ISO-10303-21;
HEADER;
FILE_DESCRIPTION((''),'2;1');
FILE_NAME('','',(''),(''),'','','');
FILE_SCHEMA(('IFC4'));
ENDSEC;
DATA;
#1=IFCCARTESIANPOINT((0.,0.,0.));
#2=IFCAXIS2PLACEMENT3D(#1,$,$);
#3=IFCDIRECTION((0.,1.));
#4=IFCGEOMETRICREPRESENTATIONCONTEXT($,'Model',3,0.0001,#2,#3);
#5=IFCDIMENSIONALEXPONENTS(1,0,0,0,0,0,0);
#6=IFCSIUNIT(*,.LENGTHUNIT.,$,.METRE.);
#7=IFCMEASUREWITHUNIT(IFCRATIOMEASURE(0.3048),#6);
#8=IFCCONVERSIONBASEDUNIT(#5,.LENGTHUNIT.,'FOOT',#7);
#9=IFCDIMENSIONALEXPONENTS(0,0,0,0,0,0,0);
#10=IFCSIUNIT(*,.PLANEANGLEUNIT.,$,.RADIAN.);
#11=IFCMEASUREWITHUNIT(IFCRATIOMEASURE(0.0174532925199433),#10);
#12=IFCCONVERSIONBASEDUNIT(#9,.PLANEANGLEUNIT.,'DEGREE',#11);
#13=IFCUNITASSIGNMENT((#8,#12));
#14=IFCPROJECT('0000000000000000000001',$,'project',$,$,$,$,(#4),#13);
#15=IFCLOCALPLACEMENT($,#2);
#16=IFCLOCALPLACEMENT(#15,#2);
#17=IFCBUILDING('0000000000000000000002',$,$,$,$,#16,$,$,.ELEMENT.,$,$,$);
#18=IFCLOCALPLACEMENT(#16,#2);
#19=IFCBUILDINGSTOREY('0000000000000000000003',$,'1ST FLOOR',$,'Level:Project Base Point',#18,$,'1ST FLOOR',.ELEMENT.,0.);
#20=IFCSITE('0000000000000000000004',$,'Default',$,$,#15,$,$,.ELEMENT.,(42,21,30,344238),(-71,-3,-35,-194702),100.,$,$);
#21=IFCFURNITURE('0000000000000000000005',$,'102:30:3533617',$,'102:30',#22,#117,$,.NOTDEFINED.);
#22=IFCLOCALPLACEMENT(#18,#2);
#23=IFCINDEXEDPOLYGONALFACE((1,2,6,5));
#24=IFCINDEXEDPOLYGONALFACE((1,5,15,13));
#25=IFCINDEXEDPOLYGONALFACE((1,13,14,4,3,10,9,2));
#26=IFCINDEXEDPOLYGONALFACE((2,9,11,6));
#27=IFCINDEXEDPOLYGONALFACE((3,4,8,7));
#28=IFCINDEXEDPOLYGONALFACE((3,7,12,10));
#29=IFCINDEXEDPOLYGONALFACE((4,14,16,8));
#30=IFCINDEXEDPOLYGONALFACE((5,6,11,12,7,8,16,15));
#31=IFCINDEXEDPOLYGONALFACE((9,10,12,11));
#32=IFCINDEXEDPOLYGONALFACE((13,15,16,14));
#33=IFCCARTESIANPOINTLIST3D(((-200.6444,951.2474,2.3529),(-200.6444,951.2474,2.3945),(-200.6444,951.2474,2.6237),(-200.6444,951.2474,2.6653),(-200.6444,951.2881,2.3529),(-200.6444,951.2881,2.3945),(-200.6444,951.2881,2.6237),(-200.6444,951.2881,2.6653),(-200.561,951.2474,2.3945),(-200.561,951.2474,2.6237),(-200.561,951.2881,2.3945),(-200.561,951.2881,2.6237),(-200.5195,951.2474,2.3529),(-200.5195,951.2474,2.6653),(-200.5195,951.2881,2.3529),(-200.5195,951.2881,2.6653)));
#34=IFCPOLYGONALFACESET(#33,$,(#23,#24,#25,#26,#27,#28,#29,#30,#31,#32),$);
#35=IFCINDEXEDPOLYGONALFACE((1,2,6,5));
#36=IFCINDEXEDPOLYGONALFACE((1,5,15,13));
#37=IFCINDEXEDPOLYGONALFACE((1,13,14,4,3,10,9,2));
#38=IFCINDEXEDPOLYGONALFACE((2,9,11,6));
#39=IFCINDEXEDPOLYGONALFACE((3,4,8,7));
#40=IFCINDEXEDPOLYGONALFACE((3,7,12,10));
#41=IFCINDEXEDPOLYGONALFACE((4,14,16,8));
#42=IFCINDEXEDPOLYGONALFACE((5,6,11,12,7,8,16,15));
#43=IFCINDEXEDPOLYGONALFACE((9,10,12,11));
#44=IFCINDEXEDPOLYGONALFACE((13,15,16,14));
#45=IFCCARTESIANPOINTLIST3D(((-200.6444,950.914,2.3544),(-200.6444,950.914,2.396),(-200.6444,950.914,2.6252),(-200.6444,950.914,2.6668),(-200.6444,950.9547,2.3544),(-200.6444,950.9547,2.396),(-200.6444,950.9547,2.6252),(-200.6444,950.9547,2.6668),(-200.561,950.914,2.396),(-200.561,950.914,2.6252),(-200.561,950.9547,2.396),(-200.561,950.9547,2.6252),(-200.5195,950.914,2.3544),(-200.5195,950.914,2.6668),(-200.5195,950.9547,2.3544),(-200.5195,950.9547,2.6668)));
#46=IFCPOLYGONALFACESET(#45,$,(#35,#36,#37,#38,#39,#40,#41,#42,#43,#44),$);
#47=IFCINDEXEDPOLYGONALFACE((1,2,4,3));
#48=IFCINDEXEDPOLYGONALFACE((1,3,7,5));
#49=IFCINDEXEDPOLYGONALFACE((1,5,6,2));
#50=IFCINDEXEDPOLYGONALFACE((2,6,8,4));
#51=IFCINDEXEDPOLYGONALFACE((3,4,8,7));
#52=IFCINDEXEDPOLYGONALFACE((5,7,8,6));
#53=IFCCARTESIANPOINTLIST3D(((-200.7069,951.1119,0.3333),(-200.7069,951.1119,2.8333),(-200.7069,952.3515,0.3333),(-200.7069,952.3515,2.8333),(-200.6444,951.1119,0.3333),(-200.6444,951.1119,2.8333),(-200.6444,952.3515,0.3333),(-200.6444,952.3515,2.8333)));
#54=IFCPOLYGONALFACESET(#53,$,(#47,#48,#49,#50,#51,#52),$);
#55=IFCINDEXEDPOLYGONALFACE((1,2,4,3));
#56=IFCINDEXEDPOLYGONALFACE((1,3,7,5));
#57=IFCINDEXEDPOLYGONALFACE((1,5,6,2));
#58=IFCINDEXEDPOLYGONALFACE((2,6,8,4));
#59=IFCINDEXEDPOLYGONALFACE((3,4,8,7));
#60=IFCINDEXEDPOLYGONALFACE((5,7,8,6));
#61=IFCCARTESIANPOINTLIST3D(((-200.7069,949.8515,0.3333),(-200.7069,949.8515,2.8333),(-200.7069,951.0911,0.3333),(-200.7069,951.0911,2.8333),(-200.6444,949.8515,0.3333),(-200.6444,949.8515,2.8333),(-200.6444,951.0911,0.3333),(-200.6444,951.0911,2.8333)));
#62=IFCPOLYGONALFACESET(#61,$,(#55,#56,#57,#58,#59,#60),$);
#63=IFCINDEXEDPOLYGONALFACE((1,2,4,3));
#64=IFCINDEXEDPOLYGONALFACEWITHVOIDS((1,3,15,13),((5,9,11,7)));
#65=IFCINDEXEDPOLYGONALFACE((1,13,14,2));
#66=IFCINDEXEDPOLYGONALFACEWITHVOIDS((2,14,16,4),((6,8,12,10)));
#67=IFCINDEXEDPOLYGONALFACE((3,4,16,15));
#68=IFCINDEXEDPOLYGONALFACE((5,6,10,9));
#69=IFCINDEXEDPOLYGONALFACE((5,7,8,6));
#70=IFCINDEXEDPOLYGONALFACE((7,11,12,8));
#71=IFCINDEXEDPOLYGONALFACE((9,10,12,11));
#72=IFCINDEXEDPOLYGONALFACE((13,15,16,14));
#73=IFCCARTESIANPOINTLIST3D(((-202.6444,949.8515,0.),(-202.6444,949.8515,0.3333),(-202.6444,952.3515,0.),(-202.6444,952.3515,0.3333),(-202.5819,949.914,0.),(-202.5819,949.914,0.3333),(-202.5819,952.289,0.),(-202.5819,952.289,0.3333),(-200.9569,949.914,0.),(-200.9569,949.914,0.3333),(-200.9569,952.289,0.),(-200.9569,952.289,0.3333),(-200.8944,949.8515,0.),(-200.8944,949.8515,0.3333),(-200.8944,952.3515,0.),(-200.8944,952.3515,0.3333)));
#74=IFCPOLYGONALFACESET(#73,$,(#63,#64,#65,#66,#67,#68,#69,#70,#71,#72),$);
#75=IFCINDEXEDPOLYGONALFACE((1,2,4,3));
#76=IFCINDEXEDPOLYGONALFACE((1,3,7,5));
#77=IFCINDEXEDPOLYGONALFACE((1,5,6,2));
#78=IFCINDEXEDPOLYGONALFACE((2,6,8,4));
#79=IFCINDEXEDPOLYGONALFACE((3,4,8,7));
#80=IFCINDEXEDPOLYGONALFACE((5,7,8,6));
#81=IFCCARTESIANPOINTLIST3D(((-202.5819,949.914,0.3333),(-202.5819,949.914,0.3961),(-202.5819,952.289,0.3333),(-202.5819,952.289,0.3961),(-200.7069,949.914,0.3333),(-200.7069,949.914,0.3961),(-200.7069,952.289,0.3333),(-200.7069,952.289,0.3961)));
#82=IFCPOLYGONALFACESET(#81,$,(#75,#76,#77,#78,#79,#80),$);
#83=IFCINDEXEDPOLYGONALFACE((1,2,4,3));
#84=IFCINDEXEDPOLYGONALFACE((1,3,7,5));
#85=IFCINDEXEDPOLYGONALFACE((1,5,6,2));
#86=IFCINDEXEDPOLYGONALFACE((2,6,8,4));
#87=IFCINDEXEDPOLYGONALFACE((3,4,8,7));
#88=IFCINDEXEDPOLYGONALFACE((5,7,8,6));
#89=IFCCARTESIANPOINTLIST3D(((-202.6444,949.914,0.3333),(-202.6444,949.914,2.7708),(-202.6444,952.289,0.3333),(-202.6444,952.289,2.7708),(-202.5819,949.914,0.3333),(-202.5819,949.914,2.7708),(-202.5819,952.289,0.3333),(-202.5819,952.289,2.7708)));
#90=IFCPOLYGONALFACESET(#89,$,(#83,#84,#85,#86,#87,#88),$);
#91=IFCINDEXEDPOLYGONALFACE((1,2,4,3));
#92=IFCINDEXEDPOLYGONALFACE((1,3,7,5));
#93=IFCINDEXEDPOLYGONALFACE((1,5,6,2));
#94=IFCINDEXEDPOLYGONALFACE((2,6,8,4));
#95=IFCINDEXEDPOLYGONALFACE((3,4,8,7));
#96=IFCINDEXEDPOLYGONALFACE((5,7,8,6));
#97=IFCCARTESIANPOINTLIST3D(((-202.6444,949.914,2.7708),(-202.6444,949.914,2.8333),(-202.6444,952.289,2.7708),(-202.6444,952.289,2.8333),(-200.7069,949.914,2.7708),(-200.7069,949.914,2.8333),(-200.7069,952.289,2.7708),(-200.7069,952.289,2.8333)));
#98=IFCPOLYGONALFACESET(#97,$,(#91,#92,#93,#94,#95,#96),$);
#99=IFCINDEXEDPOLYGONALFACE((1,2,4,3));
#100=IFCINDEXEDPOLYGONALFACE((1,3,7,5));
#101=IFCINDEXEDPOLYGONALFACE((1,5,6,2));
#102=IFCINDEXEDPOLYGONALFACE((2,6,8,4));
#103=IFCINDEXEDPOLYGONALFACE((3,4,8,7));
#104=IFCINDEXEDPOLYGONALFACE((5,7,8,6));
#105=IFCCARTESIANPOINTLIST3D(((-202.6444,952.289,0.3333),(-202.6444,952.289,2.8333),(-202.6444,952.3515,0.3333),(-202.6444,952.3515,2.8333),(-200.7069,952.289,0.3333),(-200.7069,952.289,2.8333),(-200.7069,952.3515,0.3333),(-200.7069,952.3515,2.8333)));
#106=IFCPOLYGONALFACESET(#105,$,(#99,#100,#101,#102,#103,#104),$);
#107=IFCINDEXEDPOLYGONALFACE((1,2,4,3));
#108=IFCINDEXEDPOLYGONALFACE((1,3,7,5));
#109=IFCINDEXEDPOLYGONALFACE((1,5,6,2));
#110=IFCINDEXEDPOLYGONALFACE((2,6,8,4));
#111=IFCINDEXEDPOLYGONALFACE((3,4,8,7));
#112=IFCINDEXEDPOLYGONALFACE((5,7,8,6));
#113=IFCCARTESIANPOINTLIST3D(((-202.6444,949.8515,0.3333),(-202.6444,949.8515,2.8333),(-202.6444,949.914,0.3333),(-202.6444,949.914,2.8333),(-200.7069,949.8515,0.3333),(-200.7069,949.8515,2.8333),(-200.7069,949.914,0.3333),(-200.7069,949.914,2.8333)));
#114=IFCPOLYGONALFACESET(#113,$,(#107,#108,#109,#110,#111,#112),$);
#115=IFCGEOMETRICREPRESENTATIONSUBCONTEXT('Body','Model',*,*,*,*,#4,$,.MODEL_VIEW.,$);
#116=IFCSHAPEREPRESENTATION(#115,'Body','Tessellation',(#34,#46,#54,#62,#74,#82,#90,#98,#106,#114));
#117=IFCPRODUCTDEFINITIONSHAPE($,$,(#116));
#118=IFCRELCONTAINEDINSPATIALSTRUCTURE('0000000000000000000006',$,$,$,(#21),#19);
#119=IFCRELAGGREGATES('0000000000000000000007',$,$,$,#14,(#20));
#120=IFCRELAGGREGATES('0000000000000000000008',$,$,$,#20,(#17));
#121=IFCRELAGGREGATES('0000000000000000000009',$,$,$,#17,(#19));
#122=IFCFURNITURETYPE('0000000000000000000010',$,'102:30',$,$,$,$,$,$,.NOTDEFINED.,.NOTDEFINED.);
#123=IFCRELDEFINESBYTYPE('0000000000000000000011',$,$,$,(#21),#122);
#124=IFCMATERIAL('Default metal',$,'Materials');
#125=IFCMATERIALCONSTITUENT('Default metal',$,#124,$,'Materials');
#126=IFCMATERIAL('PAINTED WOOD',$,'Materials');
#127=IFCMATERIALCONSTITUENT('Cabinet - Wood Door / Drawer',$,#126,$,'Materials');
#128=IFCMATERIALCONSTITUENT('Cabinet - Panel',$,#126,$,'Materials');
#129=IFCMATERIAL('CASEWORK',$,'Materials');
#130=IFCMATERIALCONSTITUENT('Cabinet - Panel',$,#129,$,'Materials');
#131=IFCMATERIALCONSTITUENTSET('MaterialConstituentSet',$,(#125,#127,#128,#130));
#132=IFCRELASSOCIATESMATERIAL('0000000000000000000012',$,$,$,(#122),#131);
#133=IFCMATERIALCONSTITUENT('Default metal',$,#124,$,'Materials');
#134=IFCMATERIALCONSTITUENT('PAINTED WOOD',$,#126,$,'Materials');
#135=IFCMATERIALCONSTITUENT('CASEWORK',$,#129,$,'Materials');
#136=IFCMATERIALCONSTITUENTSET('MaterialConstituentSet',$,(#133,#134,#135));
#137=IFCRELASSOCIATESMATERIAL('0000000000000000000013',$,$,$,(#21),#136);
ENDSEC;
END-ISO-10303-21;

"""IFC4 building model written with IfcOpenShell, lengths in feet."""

from ifc_helpers import new_model, entity, si_unit, converted_unit, direction, frame, frame_2d, origin, origin_2d_with_axis, place, context, subcontext, project, spatial, polyline, rectangle, outline, extrude, source, transform, mapped, material, constituent, constituent_set, type_object, type_shapes, element, save


model = new_model("IFC4")

# Units and contexts
model_context = context("Model", 3, precision=0.0001, world=origin(), true_north=direction((0.0, 1.0)))
body_context = subcontext(model_context, "Body", "Model", "MODEL_VIEW")
ifc_project = project(units=[converted_unit("LENGTHUNIT", "FOOT", entity("IfcRatioMeasure", 0.3048), si_unit("LENGTHUNIT", "METRE"), dimensions=[1, 0, 0, 0, 0, 0, 0]), converted_unit("PLANEANGLEUNIT", "DEGREE", entity("IfcRatioMeasure", 0.0174532925199433), si_unit("PLANEANGLEUNIT", "RADIAN"), dimensions=[0, 0, 0, 0, 0, 0, 0])], contexts=[model_context])

# Site, building, storey
site_placement = place(None, origin())
site = spatial("IfcSite", under=ifc_project, at=site_placement, Name="Default", CompositionType="ELEMENT", RefLatitude=(42, 21, 30, 344238), RefLongitude=(-71, -3, -35, -194702), RefElevation=100.0)
building_placement = place(site_placement, origin())
building = spatial("IfcBuilding", under=site, at=building_placement, CompositionType="ELEMENT")
storey_placement = place(building_placement, origin())
storey = spatial("IfcBuildingStorey", under=building, at=storey_placement, Name="1ST FLOOR", ObjectType="Level:Project Base Point", LongName="1ST FLOOR", CompositionType="ELEMENT", Elevation=0.0)

# Shared definitions
ifc_material_1 = material(Name="Default metal", Category="Materials")
ifc_material_2 = material(Name="PAINTED WOOD", Category="Materials")
ifc_material_3 = material(Name="CASEWORK", Category="Materials")

# Furniture
ifc_constituent_1 = constituent(ifc_material_1, Name="Default metal", Category="Materials")
ifc_constituent_2 = constituent(ifc_material_2, Name="PAINTED WOOD", Category="Materials")
ifc_constituent_3 = constituent(ifc_material_3, Name="CASEWORK", Category="Materials")
ifc_constituent_set_1 = constituent_set(constituents=[ifc_constituent_1, ifc_constituent_2, ifc_constituent_3], Name="MaterialConstituentSet")
ifc_constituent_4 = constituent(ifc_material_1, Name="Default metal", Category="Materials")
ifc_constituent_5 = constituent(ifc_material_2, Name="Cabinet - Wood Door / Drawer", Category="Materials")
ifc_constituent_6 = constituent(ifc_material_2, Name="Cabinet - Panel", Category="Materials")
ifc_constituent_7 = constituent(ifc_material_3, Name="Cabinet - Panel", Category="Materials")
ifc_constituent_set_2 = constituent_set(constituents=[ifc_constituent_4, ifc_constituent_5, ifc_constituent_6, ifc_constituent_7], Name="MaterialConstituentSet")
furniture_type_1 = type_object("IfcFurnitureType", Name="102:30", AssemblyPlace="NOTDEFINED", PredefinedType="NOTDEFINED", material=ifc_constituent_set_2)
shared_shape_1 = source(origin(), body_context, "Body", "SweptSolid", [
    extrude(outline(polyline([(0.1146, -0.0521), (0.1562, -0.0521), (0.1562, 0.0729), (-0.1562, 0.0729), (-0.1562, -0.0521), (-0.1146, -0.0521), (-0.1146, 0.0313), (0.1146, 0.0313), (0.1146, -0.0521)])), frame((0.2073, -2.0521, 2.5091), z_axis=(1.0, 0.0, 0.0), x_axis=(0.0, 0.0, 1.0)), (0.0, 0.0, 1.0), 0.0407),
    extrude(outline(polyline([(0.1146, -0.0521), (0.1562, -0.0521), (0.1562, 0.0729), (-0.1562, 0.0729), (-0.1562, -0.0521), (-0.1146, -0.0521), (-0.1146, 0.0313), (0.1146, 0.0313), (0.1146, -0.0521)])), frame((-0.126, -2.0521, 2.5106), z_axis=(1.0, 0.0, 0.0), x_axis=(0.0, 0.0, 1.0)), (0.0, 0.0, 1.0), 0.0407),
    extrude(rectangle(XDim=0.0625, YDim=1.2396, at=frame_2d((0.0, 0.0), x_axis=(1.0, 0.0))), frame((0.6917, -1.9688, 0.3333), z_axis=(0.0, 0.0, 1.0), x_axis=(0.0, 1.0, 0.0)), (0.0, 0.0, 1.0), 2.5),
    extrude(rectangle(XDim=0.0625, YDim=1.2396, at=origin_2d_with_axis()), frame((-0.5687, -1.9688, 0.3333), z_axis=(0.0, 0.0, 1.0), x_axis=(0.0, 1.0, 0.0)), (0.0, 0.0, 1.0), 2.5),
    extrude(outline(polyline([(-1.25, -0.875), (1.25, -0.875), (1.25, 0.875), (-1.25, 0.875), (-1.25, -0.875)]), holes=[polyline([(-1.1875, -0.8125), (-1.1875, 0.8125), (1.1875, 0.8125), (1.1875, -0.8125), (-1.1875, -0.8125)])]), frame((0.0615, -0.875, 0.0)), (0.0, 0.0, 1.0), 0.3333),
    extrude(rectangle(XDim=2.375, YDim=1.875, at=frame_2d((0.0, 0.0), x_axis=(1.0, 0.0))), frame((0.0615, -1.0, 0.3333), z_axis=(0.0, 0.0, 1.0), x_axis=(-1.0, 0.0, 0.0)), (0.0, 0.0, 1.0), 0.0627),
    extrude(rectangle(XDim=0.0625, YDim=2.375, at=origin_2d_with_axis()), frame((0.0615, -0.0312, 0.3333), z_axis=(0.0, 0.0, 1.0), x_axis=(0.0, 1.0, 0.0)), (0.0, 0.0, 1.0), 2.4375),
    extrude(rectangle(XDim=2.375, YDim=1.9375, at=origin_2d_with_axis()), frame((0.0615, -0.9688, 2.7708), z_axis=(0.0, 0.0, 1.0), x_axis=(-1.0, 0.0, 0.0)), (0.0, 0.0, 1.0), 0.0625),
    extrude(rectangle(XDim=0.0625, YDim=1.9375, at=frame_2d((0.0, 0.0), x_axis=(1.0, 0.0))), frame((1.2802, -0.9687, 0.3333)), (0.0, 0.0, 1.0), 2.5),
    extrude(rectangle(XDim=0.0625, YDim=1.9375, at=frame_2d((0.0, 0.0), x_axis=(1.0, 0.0))), frame((-1.1573, -0.9687, 0.3333)), (0.0, 0.0, 1.0), 2.5),
])
type_shapes(furniture_type_1, [shared_shape_1])
furniture_1_placement = place(storey_placement, frame((-202.6444, 951.04, 0.0), z_axis=(0.0, 0.0, 1.0), x_axis=(0.0, 1.0, 0.0)))
element("IfcFurniture", 1, at=furniture_1_placement, inside=storey, type_object=furniture_type_1, material=ifc_constituent_set_1, Name="102:30:3533617", ObjectType="102:30", PredefinedType="NOTDEFINED", context=body_context, shape_type="MappedRepresentation", body=[
    mapped(shared_shape_1, transform((0.0, 0.0, 0.0), scale=1.0)),
])

save(model, "model.ifc")
